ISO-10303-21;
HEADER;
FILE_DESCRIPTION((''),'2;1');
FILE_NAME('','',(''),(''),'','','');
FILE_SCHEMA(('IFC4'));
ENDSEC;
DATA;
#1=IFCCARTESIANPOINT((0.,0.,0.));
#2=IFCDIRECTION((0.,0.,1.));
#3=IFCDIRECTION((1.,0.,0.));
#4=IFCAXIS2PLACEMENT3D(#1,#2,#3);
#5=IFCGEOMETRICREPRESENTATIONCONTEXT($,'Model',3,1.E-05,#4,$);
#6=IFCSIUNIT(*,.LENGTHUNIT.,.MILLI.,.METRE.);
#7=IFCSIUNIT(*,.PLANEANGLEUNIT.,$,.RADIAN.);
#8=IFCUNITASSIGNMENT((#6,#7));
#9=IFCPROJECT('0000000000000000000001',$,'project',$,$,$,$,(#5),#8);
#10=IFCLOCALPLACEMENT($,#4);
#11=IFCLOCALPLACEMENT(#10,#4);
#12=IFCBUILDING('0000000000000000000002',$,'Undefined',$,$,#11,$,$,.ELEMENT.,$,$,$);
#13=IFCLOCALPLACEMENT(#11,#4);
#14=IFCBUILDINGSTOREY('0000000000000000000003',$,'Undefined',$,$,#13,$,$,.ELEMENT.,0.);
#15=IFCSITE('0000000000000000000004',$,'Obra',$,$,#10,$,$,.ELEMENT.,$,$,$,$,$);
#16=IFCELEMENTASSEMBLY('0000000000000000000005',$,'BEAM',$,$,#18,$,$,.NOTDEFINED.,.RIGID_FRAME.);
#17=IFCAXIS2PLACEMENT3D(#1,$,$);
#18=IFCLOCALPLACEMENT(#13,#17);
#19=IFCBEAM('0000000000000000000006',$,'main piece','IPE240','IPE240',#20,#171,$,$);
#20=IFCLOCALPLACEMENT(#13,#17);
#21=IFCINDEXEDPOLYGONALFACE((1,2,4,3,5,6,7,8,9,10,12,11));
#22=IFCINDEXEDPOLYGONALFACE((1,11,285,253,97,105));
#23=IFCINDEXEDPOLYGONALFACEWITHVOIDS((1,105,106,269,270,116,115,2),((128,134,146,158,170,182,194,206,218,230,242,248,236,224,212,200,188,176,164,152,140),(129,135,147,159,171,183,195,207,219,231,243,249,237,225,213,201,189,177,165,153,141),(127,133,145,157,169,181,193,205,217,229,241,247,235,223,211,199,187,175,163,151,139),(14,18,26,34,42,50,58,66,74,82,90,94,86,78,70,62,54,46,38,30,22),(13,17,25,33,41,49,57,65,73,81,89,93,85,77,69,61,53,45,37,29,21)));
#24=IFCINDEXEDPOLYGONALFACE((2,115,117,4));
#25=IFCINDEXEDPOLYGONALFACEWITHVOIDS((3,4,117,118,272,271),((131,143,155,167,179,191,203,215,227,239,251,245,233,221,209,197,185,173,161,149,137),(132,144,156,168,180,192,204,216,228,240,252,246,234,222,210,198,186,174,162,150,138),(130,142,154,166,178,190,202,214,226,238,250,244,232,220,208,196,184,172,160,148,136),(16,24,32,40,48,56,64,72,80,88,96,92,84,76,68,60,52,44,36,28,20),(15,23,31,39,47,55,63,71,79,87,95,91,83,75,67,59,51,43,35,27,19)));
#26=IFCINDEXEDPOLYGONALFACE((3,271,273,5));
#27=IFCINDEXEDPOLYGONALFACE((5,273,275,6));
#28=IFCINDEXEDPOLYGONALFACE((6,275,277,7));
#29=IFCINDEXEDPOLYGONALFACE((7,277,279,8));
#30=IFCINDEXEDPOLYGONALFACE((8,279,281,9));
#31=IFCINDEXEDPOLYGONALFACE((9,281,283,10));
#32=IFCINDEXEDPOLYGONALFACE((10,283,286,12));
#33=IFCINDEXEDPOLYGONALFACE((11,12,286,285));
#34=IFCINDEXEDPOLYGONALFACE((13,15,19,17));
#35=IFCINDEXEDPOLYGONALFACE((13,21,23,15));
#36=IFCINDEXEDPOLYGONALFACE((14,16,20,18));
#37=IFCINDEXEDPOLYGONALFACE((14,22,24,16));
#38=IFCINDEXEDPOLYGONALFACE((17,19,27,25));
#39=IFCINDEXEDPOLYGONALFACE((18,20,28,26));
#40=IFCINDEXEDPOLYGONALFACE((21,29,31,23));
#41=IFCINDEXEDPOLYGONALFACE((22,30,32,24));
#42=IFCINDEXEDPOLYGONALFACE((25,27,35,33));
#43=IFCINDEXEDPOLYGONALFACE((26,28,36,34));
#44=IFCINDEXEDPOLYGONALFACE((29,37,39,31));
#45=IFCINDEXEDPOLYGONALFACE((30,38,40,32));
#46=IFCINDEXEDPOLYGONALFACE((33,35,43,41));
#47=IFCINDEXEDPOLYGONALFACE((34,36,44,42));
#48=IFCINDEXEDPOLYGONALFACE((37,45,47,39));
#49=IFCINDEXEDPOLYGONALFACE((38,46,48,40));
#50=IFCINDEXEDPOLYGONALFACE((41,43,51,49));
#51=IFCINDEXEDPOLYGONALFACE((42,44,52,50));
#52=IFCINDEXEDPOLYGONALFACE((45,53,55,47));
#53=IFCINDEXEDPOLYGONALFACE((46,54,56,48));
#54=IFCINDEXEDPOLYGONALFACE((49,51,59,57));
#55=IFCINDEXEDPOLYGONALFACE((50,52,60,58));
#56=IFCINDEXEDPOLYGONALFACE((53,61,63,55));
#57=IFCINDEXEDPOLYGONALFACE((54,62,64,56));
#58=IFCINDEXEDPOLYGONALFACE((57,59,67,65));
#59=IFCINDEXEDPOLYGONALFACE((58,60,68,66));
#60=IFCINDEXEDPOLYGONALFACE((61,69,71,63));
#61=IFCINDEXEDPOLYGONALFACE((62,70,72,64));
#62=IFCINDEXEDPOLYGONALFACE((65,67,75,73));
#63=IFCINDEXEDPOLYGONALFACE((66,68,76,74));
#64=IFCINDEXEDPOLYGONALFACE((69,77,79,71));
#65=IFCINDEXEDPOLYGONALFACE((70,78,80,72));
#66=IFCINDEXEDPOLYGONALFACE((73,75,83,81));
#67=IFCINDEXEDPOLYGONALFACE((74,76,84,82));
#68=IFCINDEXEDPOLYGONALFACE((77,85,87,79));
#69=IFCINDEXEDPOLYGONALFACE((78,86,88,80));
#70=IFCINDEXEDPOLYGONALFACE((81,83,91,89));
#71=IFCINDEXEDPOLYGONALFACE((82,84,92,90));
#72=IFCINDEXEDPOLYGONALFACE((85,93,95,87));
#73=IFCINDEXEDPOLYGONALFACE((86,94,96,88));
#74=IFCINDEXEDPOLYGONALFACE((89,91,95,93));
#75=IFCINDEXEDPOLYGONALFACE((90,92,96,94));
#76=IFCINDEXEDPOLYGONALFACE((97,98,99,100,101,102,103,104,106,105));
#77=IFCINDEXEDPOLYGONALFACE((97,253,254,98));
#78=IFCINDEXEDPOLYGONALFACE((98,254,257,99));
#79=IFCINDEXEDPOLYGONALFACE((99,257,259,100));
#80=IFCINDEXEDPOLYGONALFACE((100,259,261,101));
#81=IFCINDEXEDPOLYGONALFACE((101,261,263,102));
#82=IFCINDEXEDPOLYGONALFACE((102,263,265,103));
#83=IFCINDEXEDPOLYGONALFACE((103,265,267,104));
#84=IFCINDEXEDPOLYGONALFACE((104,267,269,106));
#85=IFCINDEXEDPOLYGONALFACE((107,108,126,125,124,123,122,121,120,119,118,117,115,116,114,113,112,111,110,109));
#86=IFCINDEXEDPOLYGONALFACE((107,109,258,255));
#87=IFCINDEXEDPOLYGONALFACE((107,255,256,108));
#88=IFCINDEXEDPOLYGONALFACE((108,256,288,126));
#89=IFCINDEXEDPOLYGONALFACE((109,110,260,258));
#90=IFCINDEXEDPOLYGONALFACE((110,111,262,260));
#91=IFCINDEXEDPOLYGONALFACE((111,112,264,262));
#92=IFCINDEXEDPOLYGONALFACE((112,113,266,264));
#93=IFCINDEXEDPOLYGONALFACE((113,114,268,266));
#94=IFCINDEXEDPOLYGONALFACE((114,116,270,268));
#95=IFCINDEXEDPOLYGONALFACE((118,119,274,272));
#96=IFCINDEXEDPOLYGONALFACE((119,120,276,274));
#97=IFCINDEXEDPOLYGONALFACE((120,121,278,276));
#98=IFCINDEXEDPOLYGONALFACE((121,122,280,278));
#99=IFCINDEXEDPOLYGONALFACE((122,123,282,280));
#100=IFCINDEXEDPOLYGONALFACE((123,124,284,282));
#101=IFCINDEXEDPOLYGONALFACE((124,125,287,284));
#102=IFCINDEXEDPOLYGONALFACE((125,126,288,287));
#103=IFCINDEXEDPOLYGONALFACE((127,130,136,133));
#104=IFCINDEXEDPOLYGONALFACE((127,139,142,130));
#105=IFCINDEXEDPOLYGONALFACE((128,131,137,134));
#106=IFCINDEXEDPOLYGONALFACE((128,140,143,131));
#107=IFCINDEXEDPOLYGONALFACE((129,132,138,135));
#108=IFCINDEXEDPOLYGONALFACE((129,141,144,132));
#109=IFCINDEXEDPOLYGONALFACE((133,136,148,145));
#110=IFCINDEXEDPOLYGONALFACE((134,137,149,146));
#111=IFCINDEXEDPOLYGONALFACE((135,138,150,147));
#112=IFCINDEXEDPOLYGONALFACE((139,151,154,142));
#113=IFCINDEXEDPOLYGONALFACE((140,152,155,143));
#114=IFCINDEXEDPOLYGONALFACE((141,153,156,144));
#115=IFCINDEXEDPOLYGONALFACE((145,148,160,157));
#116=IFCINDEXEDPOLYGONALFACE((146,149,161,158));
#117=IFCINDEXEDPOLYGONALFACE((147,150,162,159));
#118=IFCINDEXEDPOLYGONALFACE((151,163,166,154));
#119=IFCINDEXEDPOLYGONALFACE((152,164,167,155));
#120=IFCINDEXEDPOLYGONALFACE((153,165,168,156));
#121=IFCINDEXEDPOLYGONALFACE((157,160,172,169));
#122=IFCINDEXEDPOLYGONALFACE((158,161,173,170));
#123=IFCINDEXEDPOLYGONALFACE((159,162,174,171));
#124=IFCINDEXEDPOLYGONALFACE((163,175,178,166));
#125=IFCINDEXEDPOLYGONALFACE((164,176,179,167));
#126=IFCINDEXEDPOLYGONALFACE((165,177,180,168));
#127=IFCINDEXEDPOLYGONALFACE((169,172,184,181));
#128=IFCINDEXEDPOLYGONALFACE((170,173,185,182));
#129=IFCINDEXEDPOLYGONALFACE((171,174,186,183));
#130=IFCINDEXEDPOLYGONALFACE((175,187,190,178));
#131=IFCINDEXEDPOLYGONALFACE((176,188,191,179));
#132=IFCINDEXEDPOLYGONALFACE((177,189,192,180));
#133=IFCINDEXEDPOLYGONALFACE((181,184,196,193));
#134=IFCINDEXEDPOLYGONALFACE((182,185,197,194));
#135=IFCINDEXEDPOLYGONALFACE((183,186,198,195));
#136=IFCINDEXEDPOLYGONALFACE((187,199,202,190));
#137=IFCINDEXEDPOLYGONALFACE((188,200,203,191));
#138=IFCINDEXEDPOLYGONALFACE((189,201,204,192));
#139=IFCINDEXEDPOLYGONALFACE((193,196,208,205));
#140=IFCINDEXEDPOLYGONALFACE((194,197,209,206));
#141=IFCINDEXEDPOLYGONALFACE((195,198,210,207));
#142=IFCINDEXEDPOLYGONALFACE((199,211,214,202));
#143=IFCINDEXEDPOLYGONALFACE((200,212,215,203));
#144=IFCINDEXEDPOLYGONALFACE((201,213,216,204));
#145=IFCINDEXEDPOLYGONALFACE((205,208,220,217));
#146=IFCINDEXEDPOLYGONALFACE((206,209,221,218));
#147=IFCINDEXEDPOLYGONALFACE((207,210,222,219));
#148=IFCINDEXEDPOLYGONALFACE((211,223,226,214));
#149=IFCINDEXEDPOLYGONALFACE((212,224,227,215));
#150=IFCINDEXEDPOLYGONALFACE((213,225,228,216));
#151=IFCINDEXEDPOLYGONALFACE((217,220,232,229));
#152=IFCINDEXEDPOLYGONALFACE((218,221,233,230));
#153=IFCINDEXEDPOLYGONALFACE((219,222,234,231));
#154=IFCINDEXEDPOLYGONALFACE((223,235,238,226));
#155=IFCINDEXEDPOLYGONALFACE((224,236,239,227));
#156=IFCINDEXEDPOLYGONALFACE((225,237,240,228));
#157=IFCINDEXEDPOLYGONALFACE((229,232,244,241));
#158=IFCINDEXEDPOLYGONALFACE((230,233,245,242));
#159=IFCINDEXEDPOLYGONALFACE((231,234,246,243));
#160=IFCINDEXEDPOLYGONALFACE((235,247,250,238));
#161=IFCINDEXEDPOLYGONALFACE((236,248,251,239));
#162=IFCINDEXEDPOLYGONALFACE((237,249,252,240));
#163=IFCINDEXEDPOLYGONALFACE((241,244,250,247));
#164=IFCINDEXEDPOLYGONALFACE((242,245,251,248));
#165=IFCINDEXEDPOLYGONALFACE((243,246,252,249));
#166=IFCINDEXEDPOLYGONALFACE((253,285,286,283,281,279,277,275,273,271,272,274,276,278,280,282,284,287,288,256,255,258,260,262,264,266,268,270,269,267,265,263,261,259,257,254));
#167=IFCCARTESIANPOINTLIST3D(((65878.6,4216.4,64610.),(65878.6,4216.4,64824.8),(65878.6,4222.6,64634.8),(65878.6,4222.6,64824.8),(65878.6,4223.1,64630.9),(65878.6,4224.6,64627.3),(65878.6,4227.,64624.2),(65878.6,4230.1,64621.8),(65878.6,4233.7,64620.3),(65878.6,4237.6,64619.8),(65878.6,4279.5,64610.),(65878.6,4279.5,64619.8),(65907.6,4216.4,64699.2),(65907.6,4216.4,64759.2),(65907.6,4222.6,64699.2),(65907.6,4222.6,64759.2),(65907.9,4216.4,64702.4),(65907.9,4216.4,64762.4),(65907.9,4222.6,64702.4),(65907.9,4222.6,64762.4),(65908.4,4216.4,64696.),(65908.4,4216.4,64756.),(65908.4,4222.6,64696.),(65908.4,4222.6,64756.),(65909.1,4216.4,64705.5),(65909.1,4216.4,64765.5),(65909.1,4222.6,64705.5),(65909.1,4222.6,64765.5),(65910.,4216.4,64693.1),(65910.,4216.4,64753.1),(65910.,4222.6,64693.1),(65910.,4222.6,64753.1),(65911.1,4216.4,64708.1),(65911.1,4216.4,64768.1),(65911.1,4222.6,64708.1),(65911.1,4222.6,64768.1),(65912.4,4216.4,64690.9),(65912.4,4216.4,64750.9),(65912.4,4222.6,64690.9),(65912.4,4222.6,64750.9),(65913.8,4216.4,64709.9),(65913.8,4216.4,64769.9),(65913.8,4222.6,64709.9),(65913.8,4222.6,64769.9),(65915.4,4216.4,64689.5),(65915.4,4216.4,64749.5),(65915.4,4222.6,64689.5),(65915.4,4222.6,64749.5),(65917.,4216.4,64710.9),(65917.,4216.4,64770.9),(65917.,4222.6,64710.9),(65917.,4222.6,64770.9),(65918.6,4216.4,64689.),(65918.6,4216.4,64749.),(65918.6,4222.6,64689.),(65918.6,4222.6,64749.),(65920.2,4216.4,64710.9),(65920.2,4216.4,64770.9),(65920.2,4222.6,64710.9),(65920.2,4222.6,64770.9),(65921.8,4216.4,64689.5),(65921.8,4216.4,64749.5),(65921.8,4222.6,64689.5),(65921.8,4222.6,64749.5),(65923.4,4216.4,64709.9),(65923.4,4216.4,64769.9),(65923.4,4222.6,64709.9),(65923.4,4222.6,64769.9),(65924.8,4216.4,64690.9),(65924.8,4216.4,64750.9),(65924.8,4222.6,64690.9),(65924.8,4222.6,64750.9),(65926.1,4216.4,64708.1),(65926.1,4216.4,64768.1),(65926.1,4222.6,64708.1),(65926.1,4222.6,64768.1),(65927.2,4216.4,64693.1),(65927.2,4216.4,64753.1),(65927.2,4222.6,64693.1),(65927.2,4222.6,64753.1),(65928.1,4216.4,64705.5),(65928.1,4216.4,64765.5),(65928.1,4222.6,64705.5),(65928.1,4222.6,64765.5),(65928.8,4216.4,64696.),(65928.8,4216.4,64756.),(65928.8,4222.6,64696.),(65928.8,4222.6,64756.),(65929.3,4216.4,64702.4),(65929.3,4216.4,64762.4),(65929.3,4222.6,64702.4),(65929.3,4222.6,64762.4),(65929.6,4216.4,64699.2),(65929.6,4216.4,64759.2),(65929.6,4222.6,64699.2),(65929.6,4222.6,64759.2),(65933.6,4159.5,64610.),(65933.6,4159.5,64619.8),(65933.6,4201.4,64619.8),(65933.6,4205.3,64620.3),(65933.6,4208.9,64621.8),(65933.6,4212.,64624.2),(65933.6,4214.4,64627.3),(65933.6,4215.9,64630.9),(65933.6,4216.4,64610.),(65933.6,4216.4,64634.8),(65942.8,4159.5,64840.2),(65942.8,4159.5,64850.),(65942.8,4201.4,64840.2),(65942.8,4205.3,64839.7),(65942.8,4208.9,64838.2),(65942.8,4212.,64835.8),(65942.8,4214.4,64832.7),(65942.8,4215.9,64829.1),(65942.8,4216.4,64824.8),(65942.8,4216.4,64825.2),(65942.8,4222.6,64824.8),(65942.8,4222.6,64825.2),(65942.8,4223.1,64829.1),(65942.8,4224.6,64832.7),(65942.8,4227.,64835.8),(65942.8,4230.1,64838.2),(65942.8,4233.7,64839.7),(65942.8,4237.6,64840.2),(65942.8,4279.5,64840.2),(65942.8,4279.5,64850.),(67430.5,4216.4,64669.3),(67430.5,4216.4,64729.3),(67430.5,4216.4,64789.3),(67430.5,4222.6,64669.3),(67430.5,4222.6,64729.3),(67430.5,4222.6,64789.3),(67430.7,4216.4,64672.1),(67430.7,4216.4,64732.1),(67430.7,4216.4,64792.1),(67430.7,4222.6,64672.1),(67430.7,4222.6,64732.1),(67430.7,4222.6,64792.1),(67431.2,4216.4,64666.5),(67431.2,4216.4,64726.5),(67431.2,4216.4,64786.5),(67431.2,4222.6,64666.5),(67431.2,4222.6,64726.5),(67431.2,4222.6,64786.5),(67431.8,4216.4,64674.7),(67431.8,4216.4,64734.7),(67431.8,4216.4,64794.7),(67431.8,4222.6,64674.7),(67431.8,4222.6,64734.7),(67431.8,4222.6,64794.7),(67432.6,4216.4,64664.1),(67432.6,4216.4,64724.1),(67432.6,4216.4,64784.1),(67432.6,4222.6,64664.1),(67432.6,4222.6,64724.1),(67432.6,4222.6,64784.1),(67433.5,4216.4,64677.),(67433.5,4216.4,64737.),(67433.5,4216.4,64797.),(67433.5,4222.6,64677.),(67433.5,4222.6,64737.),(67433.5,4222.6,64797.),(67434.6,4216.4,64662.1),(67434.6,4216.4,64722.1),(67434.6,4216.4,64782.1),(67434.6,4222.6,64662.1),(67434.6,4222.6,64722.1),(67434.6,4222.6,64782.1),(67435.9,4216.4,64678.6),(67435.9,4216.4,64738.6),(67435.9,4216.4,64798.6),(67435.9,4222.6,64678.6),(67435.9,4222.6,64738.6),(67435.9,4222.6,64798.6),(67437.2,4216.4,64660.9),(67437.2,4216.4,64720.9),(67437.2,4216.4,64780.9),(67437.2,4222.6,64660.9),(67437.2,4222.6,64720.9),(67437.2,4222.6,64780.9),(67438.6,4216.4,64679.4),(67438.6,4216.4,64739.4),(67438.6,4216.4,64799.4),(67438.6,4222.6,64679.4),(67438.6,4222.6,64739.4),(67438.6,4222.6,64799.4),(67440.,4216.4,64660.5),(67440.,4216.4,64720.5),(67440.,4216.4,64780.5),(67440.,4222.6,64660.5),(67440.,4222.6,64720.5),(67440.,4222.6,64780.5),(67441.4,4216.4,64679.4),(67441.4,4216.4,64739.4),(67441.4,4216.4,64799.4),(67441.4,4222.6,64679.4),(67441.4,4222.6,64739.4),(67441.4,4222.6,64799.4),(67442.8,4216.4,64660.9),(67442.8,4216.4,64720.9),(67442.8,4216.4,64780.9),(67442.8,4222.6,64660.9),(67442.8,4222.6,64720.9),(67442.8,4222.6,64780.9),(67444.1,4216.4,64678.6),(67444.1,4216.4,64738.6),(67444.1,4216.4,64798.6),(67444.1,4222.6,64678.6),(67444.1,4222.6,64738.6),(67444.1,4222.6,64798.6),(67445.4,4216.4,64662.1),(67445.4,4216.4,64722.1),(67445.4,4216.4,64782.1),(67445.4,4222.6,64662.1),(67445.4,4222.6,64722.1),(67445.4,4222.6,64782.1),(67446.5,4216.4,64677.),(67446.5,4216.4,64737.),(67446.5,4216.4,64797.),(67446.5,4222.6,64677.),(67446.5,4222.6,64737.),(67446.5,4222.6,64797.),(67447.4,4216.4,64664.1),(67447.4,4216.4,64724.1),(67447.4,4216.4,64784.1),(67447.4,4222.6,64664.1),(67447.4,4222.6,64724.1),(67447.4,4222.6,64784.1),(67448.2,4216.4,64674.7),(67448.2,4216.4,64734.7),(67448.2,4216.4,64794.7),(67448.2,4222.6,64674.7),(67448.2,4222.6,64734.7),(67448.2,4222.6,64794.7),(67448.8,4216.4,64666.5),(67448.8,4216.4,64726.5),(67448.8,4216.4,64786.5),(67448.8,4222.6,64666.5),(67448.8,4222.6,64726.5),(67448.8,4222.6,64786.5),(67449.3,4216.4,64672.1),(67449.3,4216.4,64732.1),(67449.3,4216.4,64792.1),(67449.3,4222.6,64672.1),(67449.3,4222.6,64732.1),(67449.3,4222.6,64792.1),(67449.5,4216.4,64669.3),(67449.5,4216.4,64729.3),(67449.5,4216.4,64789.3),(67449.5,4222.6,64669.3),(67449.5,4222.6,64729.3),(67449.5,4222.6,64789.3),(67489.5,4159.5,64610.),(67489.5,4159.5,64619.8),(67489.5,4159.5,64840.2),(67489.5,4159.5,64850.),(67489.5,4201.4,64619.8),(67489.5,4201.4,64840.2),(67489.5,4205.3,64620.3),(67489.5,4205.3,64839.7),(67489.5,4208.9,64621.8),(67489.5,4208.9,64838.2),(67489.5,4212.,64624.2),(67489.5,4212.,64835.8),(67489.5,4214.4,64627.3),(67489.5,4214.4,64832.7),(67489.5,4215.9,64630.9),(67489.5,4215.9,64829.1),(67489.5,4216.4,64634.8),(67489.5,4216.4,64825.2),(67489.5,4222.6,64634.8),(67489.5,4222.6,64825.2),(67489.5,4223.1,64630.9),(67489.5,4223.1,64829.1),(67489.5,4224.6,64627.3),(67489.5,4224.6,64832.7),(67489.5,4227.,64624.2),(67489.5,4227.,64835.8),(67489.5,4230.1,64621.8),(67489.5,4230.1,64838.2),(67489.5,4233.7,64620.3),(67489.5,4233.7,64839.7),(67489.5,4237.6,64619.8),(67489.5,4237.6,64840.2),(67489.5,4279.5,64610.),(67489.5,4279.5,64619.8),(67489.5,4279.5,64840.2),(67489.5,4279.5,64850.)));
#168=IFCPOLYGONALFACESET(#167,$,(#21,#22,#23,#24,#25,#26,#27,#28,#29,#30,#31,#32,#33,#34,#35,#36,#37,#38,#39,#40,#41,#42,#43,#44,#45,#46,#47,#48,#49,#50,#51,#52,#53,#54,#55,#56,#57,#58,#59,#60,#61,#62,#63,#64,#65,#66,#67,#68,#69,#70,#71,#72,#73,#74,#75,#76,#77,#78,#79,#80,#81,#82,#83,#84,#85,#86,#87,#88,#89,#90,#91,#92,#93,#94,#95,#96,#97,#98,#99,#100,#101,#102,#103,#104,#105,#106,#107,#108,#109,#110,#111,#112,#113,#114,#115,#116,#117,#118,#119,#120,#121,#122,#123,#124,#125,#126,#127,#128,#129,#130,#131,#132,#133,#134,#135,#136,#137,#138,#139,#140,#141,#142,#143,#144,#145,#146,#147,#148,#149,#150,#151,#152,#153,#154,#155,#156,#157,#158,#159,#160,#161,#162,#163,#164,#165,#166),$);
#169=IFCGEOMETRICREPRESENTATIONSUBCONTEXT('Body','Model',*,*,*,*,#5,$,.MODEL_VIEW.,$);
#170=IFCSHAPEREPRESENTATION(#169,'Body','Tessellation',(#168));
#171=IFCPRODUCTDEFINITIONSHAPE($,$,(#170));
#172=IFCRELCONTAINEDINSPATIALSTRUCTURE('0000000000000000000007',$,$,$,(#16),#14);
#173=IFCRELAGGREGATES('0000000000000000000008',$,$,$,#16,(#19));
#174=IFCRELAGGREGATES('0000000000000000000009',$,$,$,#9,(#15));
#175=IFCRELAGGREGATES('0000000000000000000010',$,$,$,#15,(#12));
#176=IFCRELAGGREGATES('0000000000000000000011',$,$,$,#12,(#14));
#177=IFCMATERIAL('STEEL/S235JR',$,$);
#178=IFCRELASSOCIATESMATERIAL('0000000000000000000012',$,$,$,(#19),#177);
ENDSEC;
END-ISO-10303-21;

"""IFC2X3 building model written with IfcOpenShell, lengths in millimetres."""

from ifc_helpers import new_model, si_unit, frame, origin_with_axes, origin_2d_with_axis, place, context, subcontext, project, spatial, rectangle, circle, i_section, extrude, clip, halfspace, source, transform, mapped, material, element, aggregate, save


model = new_model("IFC2X3")

# Units and contexts
model_context = context("Model", 3, precision=1e-05, world=origin_with_axes())
body_context = subcontext(model_context, "Body", "Model", "MODEL_VIEW")
ifc_project = project(units=[si_unit("LENGTHUNIT", "METRE", prefix="MILLI"), si_unit("PLANEANGLEUNIT", "RADIAN")], contexts=[model_context])

# Site, building, storey
site_placement = place(None, origin_with_axes())
site = spatial("IfcSite", under=ifc_project, at=site_placement, Name="Obra", CompositionType="ELEMENT")
building_placement = place(site_placement, origin_with_axes())
building = spatial("IfcBuilding", under=site, at=building_placement, Name="Undefined", CompositionType="ELEMENT")
storey_placement = place(building_placement, origin_with_axes())
storey = spatial("IfcBuildingStorey", under=building, at=storey_placement, Name="Undefined", CompositionType="ELEMENT", Elevation=0.0)

# Element assembly, beam, openings
ifc_material = material(Name="STEEL/S235JR")
shared_shape_1 = source(origin_with_axes(), body_context, "Body", "SweptSolid", [
    extrude(circle(Radius=11.0, at=origin_2d_with_axis()), frame((0.0, -3.2, 0.0), z_axis=(0.0, 1.0, 0.0), x_axis=(1.0, 0.0, 0.0)), (0.0, 0.0, 1.0), 6.4),
])
shared_shape_2 = source(origin_with_axes(), body_context, "Body", "SweptSolid", [
    extrude(circle(Radius=9.5, at=origin_2d_with_axis()), frame((0.0, -3.2, 0.0), z_axis=(0.0, 1.0, 0.0), x_axis=(1.0, 0.0, 0.0)), (0.0, 0.0, 1.0), 6.4),
])
assembly_1_placement = place(storey_placement, origin_with_axes())
assembly_1 = element("IfcElementAssembly", 1, at=assembly_1_placement, inside=storey, Name="BEAM", AssemblyPlace="NOTDEFINED", PredefinedType="RIGID_FRAME")
beam_1_placement = place(assembly_1_placement, frame((65952.4, 4219.5, 64730.0), z_axis=(0.0, 0.0, 1.0), x_axis=(1.0, 0.0, 0.0)))
beam_1 = element("IfcBeam", 2, at=beam_1_placement, material=ifc_material, Name="main piece", Description="IPE240", ObjectType="IPE240", context=body_context, shape_type="Clipping", body=[
    clip(clip(extrude(i_section(OverallWidth=120.0, OverallDepth=240.0, WebThickness=6.2, FlangeThickness=9.8, FilletRadius=15.0, at=origin_2d_with_axis()), frame((1741.1, 0.0, 0.0), z_axis=(-1.0, 0.0, 0.0), x_axis=(0.0, -1.0, 0.0)), (0.0, 0.0, 1.0), 1814.9), halfspace(frame((1537.1, -60.0, -120.0), z_axis=(1.0, 0.000019, 0.0), x_axis=(0.0, 0.0, 1.0)), False)), halfspace(frame((-73.8, 0.0, -220.0), z_axis=(1.0, 0.0, 0.0), x_axis=(0.0, -1.0, 0.0)), True)),
])
opening_1_placement = place(assembly_1_placement, frame((65952.4, 4219.5, 64730.0), z_axis=(0.0, 0.0, 1.0), x_axis=(1.0, 0.0, 0.0)))
element("IfcOpeningElement", 3, at=opening_1_placement, cuts=beam_1, ObjectType="Recess", context=body_context, shape_type="SweptSolid", body=[
    extrude(rectangle(XDim=65.0, YDim=300.0, at=origin_2d_with_axis()), frame((-51.3, -153.1, 109.8), z_axis=(0.0, 0.0, -1.0), x_axis=(1.0, 0.0, 0.0)), (0.0, 0.0, 1.0), 249.6),
])
opening_2_placement = place(assembly_1_placement, frame((65952.4, 4219.5, 64730.0), z_axis=(0.0, 0.0, 1.0), x_axis=(1.0, 0.0, 0.0)))
element("IfcOpeningElement", 4, at=opening_2_placement, cuts=beam_1, ObjectType="Recess", context=body_context, shape_type="SweptSolid", body=[
    extrude(rectangle(XDim=26.2, YDim=76.2, at=origin_2d_with_axis()), frame((-47.7, -61.0, 107.9), z_axis=(0.0, 1.0, 0.0), x_axis=(0.0, 0.0, -1.0)), (0.0, 0.0, 1.0), 122.0),
])
opening_3_placement = place(assembly_1_placement, frame((65878.6, 4219.5, 64850.0), z_axis=(1.0, 0.0, 0.0), x_axis=(0.0, 0.0, -1.0)))
element("IfcOpeningElement", 5, at=opening_3_placement, cuts=beam_1, ObjectType="Opening", context=body_context, shape_type="MappedRepresentation", body=[
    mapped(shared_shape_1, transform((90.0, 0.0, 40.0))),
    mapped(shared_shape_1, transform((150.0, 0.0, 40.0))),
])
opening_4_placement = place(assembly_1_placement, frame((67490.0, 4219.5, 64850.0), z_axis=(-1.0, 0.0, 0.0), x_axis=(0.0, 0.0, -1.0)))
element("IfcOpeningElement", 6, at=opening_4_placement, cuts=beam_1, ObjectType="Opening", context=body_context, shape_type="MappedRepresentation", body=[
    mapped(shared_shape_2, transform((60.0, 0.0, 50.0))),
    mapped(shared_shape_2, transform((120.0, 0.0, 50.0))),
    mapped(shared_shape_2, transform((180.0, 0.0, 50.0))),
])
aggregate(assembly_1, [beam_1])

save(model, "model.ifc")
